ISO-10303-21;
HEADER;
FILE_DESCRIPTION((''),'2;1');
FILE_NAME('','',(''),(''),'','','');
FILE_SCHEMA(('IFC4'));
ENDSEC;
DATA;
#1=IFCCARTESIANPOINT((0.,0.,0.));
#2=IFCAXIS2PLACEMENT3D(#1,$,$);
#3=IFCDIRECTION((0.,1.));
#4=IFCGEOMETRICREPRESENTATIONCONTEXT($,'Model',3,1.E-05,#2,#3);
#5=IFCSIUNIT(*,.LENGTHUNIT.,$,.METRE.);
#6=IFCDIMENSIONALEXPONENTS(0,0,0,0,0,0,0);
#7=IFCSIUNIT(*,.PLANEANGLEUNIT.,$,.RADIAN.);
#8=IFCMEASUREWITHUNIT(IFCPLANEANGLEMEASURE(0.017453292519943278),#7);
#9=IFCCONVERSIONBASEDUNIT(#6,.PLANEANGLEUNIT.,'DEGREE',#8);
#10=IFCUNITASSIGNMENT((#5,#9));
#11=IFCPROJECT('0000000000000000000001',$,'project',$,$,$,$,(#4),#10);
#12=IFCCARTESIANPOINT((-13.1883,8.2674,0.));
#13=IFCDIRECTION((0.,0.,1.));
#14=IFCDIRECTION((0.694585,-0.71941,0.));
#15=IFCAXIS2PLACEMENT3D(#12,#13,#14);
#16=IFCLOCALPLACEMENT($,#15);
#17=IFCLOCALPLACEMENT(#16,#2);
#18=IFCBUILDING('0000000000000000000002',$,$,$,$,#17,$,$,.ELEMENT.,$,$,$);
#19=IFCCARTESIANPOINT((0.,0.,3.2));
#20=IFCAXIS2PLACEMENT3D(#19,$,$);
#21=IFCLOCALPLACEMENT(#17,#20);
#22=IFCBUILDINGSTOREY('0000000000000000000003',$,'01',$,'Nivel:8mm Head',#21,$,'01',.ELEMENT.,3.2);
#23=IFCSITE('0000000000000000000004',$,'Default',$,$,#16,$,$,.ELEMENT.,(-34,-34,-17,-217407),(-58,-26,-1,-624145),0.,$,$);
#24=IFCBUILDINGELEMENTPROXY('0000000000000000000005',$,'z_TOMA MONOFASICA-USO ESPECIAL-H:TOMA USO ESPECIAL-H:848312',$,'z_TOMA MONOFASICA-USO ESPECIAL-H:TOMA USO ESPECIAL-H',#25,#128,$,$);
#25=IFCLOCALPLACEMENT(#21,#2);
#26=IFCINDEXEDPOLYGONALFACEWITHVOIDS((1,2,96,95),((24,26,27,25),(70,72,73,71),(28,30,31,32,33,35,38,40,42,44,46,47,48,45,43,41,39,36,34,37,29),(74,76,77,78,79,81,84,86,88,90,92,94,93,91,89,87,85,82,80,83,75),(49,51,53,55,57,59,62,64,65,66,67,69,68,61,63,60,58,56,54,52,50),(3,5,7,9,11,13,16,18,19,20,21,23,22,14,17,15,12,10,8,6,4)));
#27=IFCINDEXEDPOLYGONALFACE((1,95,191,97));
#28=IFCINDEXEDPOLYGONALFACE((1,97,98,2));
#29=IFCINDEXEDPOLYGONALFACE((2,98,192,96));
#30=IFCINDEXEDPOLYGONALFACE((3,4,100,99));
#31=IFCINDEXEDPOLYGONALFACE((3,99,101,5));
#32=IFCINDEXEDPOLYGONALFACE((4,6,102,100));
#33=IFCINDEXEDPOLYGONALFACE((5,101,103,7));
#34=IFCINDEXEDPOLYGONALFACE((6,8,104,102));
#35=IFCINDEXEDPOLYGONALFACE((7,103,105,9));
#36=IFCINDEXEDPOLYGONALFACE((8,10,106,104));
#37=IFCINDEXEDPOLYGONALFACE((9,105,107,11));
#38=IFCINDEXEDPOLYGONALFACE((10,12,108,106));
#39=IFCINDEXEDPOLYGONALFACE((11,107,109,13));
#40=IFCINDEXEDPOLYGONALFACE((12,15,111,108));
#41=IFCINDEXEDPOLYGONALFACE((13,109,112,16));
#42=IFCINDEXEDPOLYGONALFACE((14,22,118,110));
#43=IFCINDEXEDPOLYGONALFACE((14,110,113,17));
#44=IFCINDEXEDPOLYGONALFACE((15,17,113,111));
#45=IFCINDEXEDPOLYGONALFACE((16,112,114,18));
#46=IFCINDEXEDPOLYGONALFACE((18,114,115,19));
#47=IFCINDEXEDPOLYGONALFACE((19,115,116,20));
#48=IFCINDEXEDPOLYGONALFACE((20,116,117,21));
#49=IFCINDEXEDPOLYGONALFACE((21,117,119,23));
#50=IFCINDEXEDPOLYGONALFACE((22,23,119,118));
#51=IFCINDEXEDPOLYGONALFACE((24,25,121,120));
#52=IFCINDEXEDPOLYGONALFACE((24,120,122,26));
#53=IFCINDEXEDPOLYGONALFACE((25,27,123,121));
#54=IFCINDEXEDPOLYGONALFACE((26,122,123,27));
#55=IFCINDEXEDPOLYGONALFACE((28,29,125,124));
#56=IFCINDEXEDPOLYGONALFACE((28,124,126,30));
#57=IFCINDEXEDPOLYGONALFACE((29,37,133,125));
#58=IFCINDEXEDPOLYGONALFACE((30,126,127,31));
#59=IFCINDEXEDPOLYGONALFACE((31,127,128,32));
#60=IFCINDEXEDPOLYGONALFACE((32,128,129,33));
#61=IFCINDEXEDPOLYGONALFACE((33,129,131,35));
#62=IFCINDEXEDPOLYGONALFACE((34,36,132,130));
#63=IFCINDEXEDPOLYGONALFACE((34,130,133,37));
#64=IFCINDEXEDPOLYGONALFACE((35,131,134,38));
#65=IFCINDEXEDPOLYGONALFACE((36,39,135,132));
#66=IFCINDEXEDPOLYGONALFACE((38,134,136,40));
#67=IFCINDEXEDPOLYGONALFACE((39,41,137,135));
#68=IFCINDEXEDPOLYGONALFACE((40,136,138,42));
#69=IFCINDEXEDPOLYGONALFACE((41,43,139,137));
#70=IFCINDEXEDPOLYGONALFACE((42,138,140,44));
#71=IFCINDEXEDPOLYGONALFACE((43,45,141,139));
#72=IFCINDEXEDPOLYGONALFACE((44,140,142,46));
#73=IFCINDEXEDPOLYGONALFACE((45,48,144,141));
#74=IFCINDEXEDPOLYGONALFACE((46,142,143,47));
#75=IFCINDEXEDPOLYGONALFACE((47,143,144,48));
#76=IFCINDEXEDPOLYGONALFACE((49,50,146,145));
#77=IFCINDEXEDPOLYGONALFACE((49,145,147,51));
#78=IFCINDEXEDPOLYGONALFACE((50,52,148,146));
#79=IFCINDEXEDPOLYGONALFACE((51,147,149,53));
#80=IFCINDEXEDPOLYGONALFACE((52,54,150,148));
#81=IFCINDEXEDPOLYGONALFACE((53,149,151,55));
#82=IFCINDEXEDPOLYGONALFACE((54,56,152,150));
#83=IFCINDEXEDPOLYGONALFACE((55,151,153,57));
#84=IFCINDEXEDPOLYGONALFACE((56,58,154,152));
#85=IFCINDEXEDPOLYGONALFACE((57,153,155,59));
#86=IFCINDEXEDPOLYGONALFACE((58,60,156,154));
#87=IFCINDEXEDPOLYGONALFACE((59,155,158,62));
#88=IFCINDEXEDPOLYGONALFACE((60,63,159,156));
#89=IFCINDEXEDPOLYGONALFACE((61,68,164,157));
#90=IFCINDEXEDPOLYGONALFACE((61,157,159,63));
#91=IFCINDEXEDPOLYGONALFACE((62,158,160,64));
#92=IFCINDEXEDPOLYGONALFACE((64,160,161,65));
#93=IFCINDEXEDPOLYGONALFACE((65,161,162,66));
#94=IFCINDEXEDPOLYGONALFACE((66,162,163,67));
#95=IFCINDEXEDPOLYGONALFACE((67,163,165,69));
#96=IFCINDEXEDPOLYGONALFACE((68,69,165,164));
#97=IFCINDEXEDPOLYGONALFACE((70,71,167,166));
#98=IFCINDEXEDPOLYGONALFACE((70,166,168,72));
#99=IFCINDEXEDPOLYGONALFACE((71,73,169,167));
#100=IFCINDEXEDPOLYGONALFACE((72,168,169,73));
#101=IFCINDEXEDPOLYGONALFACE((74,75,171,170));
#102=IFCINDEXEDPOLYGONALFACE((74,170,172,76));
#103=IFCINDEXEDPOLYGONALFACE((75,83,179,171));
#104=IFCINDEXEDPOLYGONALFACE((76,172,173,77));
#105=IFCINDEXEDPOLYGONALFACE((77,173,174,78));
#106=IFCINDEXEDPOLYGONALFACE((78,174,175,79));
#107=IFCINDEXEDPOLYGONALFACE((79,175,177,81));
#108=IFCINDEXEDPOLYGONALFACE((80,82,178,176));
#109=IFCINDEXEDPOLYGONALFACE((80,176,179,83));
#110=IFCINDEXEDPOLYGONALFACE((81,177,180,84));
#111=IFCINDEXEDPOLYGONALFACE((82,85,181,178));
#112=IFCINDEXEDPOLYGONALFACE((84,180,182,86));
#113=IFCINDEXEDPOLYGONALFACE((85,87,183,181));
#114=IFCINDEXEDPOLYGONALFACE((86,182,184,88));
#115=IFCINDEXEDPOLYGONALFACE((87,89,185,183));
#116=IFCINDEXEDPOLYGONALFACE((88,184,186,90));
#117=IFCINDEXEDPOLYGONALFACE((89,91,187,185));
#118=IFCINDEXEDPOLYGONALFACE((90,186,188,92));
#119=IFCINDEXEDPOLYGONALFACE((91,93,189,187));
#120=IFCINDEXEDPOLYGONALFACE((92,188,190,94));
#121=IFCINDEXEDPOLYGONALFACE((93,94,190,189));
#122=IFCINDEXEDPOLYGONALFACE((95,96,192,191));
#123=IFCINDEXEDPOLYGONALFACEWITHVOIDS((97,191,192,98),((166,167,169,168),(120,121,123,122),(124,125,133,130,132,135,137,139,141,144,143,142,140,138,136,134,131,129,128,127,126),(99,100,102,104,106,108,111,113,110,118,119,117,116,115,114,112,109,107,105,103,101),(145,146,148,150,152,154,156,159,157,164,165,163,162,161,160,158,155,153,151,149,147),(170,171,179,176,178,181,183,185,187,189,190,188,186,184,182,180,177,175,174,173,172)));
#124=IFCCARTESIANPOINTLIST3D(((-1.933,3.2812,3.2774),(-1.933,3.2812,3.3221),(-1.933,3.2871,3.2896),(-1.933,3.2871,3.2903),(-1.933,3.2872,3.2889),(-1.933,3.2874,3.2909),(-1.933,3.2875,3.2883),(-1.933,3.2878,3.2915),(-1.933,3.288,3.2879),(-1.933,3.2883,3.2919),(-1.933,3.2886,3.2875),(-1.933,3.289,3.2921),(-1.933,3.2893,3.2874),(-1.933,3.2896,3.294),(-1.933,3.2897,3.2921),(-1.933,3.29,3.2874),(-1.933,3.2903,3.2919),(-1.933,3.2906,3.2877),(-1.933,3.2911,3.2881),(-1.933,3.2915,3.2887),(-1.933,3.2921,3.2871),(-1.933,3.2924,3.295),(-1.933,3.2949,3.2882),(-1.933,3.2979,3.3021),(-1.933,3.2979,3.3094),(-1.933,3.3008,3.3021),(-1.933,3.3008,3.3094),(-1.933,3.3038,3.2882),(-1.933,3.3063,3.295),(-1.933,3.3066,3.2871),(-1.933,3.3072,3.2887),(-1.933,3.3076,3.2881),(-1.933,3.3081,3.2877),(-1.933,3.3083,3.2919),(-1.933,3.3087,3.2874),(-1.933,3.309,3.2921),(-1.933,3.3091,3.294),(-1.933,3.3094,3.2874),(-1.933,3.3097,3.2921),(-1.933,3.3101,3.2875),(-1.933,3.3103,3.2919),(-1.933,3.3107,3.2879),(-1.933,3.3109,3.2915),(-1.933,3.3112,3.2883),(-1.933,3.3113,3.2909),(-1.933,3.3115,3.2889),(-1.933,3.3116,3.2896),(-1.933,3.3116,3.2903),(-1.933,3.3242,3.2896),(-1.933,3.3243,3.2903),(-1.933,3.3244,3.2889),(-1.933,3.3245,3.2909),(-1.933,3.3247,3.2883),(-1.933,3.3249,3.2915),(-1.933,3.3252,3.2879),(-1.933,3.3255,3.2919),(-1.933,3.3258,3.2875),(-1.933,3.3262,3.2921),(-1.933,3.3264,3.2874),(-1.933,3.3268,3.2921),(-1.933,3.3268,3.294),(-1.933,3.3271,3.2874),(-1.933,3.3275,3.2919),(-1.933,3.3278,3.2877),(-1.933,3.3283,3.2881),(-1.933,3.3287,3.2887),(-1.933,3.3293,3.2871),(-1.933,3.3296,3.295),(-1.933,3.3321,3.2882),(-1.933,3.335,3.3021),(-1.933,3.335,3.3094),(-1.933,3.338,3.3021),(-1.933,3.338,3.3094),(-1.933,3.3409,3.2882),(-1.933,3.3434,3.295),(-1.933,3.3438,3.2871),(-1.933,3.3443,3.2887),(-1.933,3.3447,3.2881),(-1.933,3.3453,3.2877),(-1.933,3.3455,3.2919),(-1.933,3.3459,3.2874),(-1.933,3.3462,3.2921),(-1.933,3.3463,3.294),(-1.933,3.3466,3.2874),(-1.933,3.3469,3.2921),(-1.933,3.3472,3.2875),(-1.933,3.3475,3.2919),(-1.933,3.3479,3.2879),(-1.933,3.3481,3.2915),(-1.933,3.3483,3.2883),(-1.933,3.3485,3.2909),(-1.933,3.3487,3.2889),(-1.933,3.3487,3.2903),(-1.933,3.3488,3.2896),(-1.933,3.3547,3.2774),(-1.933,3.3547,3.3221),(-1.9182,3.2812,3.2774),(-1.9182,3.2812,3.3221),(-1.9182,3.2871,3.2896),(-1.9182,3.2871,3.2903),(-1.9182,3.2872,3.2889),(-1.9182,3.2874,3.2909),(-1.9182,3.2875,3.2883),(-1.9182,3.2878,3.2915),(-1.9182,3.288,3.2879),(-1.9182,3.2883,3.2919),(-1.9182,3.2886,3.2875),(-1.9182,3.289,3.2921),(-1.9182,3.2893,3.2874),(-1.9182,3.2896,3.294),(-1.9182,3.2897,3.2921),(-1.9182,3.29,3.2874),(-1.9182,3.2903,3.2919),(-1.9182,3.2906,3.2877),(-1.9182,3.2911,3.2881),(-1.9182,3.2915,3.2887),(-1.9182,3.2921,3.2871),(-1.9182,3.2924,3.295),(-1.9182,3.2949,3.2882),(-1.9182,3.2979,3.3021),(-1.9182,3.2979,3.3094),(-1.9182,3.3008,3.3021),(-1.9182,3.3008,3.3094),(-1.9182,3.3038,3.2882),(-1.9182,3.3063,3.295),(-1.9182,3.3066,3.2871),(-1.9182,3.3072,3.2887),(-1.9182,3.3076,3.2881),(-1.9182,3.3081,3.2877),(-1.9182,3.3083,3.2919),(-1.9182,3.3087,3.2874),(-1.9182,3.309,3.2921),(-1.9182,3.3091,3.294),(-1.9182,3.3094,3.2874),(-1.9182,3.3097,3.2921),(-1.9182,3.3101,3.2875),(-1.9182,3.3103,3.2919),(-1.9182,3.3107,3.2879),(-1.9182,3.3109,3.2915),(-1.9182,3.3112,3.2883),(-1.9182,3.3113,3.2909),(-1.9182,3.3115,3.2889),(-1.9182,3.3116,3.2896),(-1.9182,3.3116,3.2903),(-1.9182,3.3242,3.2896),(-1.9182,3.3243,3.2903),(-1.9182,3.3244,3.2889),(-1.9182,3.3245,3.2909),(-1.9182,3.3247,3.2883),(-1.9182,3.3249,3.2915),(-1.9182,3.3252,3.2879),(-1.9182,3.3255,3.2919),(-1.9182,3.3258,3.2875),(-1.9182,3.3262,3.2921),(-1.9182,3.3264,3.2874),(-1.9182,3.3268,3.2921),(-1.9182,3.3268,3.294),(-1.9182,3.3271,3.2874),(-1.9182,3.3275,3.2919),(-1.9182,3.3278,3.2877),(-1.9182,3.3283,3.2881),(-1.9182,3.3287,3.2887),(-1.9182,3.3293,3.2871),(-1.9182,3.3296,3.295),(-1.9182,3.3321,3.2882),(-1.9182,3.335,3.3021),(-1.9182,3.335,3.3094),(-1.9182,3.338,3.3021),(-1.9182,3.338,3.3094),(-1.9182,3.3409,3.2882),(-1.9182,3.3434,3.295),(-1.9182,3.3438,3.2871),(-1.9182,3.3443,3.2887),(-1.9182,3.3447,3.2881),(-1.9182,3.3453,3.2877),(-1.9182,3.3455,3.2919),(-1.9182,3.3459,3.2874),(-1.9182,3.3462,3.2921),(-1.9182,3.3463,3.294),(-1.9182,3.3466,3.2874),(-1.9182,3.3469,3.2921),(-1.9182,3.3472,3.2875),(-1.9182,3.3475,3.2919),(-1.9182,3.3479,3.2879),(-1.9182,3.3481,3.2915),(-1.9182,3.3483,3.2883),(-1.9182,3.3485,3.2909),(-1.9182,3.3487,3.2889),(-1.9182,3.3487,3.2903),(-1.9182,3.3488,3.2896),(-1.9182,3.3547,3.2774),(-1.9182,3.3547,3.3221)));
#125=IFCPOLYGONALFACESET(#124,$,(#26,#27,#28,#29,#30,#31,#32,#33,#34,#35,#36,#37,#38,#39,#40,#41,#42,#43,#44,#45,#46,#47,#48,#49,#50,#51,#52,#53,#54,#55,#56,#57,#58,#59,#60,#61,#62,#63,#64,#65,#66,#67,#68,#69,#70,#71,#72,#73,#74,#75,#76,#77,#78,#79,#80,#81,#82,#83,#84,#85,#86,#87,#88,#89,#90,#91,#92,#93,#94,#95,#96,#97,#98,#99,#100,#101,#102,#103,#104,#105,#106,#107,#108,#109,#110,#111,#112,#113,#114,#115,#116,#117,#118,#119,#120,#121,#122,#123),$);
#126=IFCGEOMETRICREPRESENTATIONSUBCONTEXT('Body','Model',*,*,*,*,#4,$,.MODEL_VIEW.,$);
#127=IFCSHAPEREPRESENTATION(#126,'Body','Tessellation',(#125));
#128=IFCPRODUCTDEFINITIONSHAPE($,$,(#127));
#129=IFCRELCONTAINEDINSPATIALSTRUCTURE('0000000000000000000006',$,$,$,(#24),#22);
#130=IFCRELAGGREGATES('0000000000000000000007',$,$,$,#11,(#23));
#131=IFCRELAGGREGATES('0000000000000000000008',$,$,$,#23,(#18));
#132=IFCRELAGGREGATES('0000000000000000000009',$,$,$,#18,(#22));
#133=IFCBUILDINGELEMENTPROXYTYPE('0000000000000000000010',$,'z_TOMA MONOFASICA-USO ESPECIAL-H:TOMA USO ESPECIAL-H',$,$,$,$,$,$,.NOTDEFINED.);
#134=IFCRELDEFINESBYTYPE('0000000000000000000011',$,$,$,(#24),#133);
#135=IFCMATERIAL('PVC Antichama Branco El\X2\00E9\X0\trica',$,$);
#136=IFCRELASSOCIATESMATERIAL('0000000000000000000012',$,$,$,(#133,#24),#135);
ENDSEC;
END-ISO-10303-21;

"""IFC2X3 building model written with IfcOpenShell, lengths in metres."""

from ifc_helpers import new_model, entity, si_unit, converted_unit, direction, frame, frame_2d, origin, place, context, subcontext, project, spatial, polyline, circle_curve, parameter, trimmed, segment, composite_curve, outline, extrude, source, transform, mapped, material, type_object, type_shapes, element, save


model = new_model("IFC2X3")

# Units and contexts
model_context = context("Model", 3, precision=1e-05, world=origin(), true_north=direction((0.0, 1.0)))
body_context = subcontext(model_context, "Body", "Model", "MODEL_VIEW")
ifc_project = project(units=[si_unit("LENGTHUNIT", "METRE"), converted_unit("PLANEANGLEUNIT", "DEGREE", entity("IfcPlaneAngleMeasure", 0.017453292519943278), si_unit("PLANEANGLEUNIT", "RADIAN"), dimensions=[0, 0, 0, 0, 0, 0, 0])], contexts=[model_context])

# Site, building, storey
site_placement = place(None, frame((-13.1883, 8.2674, 0.0), z_axis=(0.0, 0.0, 1.0), x_axis=(0.694585, -0.71941, 0.0)))
site = spatial("IfcSite", under=ifc_project, at=site_placement, Name="Default", CompositionType="ELEMENT", RefLatitude=(-34, -34, -17, -217407), RefLongitude=(-58, -26, -1, -624145), RefElevation=0.0)
building_placement = place(site_placement, origin())
building = spatial("IfcBuilding", under=site, at=building_placement, CompositionType="ELEMENT")
storey_placement = place(building_placement, frame((0.0, 0.0, 3.2)))
storey = spatial("IfcBuildingStorey", under=building, at=storey_placement, Name="01", ObjectType="Nivel:8mm Head", LongName="01", CompositionType="ELEMENT", Elevation=3.2)

# Building element proxy
ifc_material_1 = material(Name="PVC Antichama Branco Elétrica")
building_element_proxy_type_1 = type_object("IfcBuildingElementProxyType", Name="z_TOMA MONOFASICA-USO ESPECIAL-H:TOMA USO ESPECIAL-H", PredefinedType="NOTDEFINED", material=ifc_material_1)
shared_shape_1 = source(origin(), body_context, "Body", "SweptSolid", [
    extrude(outline(polyline([(-0.0368, -0.0223), (0.0368, -0.0223), (0.0368, 0.0223), (-0.0368, 0.0223), (-0.0368, -0.0223)]), holes=[composite_curve([segment(polyline([(0.0141, 0.0115), (0.0116, 0.0047)]), True, "CONTINUOUS"), segment(polyline([(0.0116, 0.0047), (0.0088, 0.0057)]), True, "CONTINUOUS"), segment(polyline([(0.0088, 0.0057), (0.0096, 0.0078)]), True, "CONTINUOUS"), segment(trimmed(circle_curve(frame_2d((0.0087, 0.0099), x_axis=(1.0, 0.0)), 0.0024), [parameter(27.118901)], [parameter(292.881099)], True, "PARAMETER"), False, "CONTINUOUS"), segment(polyline([(0.0108, 0.011), (0.0113, 0.0126)]), True, "CONTINUOUS"), segment(polyline([(0.0113, 0.0126), (0.0141, 0.0115)]), True, "CONTINUOUS")], self_intersect=False), composite_curve([segment(polyline([(0.0255, 0.0047), (0.023, 0.0115)]), True, "CONTINUOUS"), segment(polyline([(0.023, 0.0115), (0.0258, 0.0126)]), True, "CONTINUOUS"), segment(polyline([(0.0258, 0.0126), (0.0264, 0.011)]), True, "CONTINUOUS"), segment(trimmed(circle_curve(frame_2d((0.0285, 0.0099), x_axis=(1.0, 0.0)), 0.0024), [parameter(247.118901)], [parameter(152.881099)], True, "PARAMETER"), False, "CONTINUOUS"), segment(polyline([(0.0276, 0.0078), (0.0283, 0.0057)]), True, "CONTINUOUS"), segment(polyline([(0.0283, 0.0057), (0.0255, 0.0047)]), True, "CONTINUOUS")], self_intersect=False), polyline([(0.0201, -0.0024), (0.0201, -0.0097), (0.0171, -0.0097), (0.0171, -0.0024), (0.0201, -0.0024)]), composite_curve([segment(polyline([(-0.0141, 0.0115), (-0.0113, 0.0126)]), True, "CONTINUOUS"), segment(polyline([(-0.0113, 0.0126), (-0.0108, 0.011)]), True, "CONTINUOUS"), segment(trimmed(circle_curve(frame_2d((-0.0087, 0.0099), x_axis=(1.0, 0.0)), 0.0024), [parameter(247.118901)], [parameter(152.881099)], True, "PARAMETER"), False, "CONTINUOUS"), segment(polyline([(-0.0096, 0.0078), (-0.0088, 0.0057)]), True, "CONTINUOUS"), segment(polyline([(-0.0088, 0.0057), (-0.0116, 0.0047)]), True, "CONTINUOUS"), segment(polyline([(-0.0116, 0.0047), (-0.0141, 0.0115)]), True, "CONTINUOUS")], self_intersect=False), composite_curve([segment(polyline([(-0.0255, 0.0047), (-0.0283, 0.0057)]), True, "CONTINUOUS"), segment(polyline([(-0.0283, 0.0057), (-0.0276, 0.0078)]), True, "CONTINUOUS"), segment(trimmed(circle_curve(frame_2d((-0.0285, 0.0099), x_axis=(1.0, 0.0)), 0.0024), [parameter(27.118901)], [parameter(292.881099)], True, "PARAMETER"), False, "CONTINUOUS"), segment(polyline([(-0.0264, 0.011), (-0.0258, 0.0126)]), True, "CONTINUOUS"), segment(polyline([(-0.0258, 0.0126), (-0.023, 0.0115)]), True, "CONTINUOUS"), segment(polyline([(-0.023, 0.0115), (-0.0255, 0.0047)]), True, "CONTINUOUS")], self_intersect=False), polyline([(-0.0201, -0.0024), (-0.0171, -0.0024), (-0.0171, -0.0097), (-0.0201, -0.0097), (-0.0201, -0.0024)])]), frame((0.0, -0.005, 0.0223), z_axis=(0.0, 1.0, 0.0), x_axis=(1.0, 0.0, 0.0)), (0.0, 0.0, 1.0), 0.0148),
])
type_shapes(building_element_proxy_type_1, [shared_shape_1])
for number, where, z_axis, x_axis, name in (
    (1, (-1.928, 3.3179, 3.2774), (0.0, 0.0, 1.0), (0.0, -1.0, 0.0), "z_TOMA MONOFASICA-USO ESPECIAL-H:TOMA USO ESPECIAL-H:848312"),
):
    element("IfcBuildingElementProxy", number, at=place(storey_placement, frame(where, z_axis=z_axis, x_axis=x_axis)), inside=storey, type_object=building_element_proxy_type_1, material=ifc_material_1, Name=name, ObjectType="z_TOMA MONOFASICA-USO ESPECIAL-H:TOMA USO ESPECIAL-H", context=body_context, shape_type="MappedRepresentation", body=[
        mapped(shared_shape_1, transform((0.0, 0.0, 0.0), scale=1.0)),
    ])

save(model, "model.ifc")
